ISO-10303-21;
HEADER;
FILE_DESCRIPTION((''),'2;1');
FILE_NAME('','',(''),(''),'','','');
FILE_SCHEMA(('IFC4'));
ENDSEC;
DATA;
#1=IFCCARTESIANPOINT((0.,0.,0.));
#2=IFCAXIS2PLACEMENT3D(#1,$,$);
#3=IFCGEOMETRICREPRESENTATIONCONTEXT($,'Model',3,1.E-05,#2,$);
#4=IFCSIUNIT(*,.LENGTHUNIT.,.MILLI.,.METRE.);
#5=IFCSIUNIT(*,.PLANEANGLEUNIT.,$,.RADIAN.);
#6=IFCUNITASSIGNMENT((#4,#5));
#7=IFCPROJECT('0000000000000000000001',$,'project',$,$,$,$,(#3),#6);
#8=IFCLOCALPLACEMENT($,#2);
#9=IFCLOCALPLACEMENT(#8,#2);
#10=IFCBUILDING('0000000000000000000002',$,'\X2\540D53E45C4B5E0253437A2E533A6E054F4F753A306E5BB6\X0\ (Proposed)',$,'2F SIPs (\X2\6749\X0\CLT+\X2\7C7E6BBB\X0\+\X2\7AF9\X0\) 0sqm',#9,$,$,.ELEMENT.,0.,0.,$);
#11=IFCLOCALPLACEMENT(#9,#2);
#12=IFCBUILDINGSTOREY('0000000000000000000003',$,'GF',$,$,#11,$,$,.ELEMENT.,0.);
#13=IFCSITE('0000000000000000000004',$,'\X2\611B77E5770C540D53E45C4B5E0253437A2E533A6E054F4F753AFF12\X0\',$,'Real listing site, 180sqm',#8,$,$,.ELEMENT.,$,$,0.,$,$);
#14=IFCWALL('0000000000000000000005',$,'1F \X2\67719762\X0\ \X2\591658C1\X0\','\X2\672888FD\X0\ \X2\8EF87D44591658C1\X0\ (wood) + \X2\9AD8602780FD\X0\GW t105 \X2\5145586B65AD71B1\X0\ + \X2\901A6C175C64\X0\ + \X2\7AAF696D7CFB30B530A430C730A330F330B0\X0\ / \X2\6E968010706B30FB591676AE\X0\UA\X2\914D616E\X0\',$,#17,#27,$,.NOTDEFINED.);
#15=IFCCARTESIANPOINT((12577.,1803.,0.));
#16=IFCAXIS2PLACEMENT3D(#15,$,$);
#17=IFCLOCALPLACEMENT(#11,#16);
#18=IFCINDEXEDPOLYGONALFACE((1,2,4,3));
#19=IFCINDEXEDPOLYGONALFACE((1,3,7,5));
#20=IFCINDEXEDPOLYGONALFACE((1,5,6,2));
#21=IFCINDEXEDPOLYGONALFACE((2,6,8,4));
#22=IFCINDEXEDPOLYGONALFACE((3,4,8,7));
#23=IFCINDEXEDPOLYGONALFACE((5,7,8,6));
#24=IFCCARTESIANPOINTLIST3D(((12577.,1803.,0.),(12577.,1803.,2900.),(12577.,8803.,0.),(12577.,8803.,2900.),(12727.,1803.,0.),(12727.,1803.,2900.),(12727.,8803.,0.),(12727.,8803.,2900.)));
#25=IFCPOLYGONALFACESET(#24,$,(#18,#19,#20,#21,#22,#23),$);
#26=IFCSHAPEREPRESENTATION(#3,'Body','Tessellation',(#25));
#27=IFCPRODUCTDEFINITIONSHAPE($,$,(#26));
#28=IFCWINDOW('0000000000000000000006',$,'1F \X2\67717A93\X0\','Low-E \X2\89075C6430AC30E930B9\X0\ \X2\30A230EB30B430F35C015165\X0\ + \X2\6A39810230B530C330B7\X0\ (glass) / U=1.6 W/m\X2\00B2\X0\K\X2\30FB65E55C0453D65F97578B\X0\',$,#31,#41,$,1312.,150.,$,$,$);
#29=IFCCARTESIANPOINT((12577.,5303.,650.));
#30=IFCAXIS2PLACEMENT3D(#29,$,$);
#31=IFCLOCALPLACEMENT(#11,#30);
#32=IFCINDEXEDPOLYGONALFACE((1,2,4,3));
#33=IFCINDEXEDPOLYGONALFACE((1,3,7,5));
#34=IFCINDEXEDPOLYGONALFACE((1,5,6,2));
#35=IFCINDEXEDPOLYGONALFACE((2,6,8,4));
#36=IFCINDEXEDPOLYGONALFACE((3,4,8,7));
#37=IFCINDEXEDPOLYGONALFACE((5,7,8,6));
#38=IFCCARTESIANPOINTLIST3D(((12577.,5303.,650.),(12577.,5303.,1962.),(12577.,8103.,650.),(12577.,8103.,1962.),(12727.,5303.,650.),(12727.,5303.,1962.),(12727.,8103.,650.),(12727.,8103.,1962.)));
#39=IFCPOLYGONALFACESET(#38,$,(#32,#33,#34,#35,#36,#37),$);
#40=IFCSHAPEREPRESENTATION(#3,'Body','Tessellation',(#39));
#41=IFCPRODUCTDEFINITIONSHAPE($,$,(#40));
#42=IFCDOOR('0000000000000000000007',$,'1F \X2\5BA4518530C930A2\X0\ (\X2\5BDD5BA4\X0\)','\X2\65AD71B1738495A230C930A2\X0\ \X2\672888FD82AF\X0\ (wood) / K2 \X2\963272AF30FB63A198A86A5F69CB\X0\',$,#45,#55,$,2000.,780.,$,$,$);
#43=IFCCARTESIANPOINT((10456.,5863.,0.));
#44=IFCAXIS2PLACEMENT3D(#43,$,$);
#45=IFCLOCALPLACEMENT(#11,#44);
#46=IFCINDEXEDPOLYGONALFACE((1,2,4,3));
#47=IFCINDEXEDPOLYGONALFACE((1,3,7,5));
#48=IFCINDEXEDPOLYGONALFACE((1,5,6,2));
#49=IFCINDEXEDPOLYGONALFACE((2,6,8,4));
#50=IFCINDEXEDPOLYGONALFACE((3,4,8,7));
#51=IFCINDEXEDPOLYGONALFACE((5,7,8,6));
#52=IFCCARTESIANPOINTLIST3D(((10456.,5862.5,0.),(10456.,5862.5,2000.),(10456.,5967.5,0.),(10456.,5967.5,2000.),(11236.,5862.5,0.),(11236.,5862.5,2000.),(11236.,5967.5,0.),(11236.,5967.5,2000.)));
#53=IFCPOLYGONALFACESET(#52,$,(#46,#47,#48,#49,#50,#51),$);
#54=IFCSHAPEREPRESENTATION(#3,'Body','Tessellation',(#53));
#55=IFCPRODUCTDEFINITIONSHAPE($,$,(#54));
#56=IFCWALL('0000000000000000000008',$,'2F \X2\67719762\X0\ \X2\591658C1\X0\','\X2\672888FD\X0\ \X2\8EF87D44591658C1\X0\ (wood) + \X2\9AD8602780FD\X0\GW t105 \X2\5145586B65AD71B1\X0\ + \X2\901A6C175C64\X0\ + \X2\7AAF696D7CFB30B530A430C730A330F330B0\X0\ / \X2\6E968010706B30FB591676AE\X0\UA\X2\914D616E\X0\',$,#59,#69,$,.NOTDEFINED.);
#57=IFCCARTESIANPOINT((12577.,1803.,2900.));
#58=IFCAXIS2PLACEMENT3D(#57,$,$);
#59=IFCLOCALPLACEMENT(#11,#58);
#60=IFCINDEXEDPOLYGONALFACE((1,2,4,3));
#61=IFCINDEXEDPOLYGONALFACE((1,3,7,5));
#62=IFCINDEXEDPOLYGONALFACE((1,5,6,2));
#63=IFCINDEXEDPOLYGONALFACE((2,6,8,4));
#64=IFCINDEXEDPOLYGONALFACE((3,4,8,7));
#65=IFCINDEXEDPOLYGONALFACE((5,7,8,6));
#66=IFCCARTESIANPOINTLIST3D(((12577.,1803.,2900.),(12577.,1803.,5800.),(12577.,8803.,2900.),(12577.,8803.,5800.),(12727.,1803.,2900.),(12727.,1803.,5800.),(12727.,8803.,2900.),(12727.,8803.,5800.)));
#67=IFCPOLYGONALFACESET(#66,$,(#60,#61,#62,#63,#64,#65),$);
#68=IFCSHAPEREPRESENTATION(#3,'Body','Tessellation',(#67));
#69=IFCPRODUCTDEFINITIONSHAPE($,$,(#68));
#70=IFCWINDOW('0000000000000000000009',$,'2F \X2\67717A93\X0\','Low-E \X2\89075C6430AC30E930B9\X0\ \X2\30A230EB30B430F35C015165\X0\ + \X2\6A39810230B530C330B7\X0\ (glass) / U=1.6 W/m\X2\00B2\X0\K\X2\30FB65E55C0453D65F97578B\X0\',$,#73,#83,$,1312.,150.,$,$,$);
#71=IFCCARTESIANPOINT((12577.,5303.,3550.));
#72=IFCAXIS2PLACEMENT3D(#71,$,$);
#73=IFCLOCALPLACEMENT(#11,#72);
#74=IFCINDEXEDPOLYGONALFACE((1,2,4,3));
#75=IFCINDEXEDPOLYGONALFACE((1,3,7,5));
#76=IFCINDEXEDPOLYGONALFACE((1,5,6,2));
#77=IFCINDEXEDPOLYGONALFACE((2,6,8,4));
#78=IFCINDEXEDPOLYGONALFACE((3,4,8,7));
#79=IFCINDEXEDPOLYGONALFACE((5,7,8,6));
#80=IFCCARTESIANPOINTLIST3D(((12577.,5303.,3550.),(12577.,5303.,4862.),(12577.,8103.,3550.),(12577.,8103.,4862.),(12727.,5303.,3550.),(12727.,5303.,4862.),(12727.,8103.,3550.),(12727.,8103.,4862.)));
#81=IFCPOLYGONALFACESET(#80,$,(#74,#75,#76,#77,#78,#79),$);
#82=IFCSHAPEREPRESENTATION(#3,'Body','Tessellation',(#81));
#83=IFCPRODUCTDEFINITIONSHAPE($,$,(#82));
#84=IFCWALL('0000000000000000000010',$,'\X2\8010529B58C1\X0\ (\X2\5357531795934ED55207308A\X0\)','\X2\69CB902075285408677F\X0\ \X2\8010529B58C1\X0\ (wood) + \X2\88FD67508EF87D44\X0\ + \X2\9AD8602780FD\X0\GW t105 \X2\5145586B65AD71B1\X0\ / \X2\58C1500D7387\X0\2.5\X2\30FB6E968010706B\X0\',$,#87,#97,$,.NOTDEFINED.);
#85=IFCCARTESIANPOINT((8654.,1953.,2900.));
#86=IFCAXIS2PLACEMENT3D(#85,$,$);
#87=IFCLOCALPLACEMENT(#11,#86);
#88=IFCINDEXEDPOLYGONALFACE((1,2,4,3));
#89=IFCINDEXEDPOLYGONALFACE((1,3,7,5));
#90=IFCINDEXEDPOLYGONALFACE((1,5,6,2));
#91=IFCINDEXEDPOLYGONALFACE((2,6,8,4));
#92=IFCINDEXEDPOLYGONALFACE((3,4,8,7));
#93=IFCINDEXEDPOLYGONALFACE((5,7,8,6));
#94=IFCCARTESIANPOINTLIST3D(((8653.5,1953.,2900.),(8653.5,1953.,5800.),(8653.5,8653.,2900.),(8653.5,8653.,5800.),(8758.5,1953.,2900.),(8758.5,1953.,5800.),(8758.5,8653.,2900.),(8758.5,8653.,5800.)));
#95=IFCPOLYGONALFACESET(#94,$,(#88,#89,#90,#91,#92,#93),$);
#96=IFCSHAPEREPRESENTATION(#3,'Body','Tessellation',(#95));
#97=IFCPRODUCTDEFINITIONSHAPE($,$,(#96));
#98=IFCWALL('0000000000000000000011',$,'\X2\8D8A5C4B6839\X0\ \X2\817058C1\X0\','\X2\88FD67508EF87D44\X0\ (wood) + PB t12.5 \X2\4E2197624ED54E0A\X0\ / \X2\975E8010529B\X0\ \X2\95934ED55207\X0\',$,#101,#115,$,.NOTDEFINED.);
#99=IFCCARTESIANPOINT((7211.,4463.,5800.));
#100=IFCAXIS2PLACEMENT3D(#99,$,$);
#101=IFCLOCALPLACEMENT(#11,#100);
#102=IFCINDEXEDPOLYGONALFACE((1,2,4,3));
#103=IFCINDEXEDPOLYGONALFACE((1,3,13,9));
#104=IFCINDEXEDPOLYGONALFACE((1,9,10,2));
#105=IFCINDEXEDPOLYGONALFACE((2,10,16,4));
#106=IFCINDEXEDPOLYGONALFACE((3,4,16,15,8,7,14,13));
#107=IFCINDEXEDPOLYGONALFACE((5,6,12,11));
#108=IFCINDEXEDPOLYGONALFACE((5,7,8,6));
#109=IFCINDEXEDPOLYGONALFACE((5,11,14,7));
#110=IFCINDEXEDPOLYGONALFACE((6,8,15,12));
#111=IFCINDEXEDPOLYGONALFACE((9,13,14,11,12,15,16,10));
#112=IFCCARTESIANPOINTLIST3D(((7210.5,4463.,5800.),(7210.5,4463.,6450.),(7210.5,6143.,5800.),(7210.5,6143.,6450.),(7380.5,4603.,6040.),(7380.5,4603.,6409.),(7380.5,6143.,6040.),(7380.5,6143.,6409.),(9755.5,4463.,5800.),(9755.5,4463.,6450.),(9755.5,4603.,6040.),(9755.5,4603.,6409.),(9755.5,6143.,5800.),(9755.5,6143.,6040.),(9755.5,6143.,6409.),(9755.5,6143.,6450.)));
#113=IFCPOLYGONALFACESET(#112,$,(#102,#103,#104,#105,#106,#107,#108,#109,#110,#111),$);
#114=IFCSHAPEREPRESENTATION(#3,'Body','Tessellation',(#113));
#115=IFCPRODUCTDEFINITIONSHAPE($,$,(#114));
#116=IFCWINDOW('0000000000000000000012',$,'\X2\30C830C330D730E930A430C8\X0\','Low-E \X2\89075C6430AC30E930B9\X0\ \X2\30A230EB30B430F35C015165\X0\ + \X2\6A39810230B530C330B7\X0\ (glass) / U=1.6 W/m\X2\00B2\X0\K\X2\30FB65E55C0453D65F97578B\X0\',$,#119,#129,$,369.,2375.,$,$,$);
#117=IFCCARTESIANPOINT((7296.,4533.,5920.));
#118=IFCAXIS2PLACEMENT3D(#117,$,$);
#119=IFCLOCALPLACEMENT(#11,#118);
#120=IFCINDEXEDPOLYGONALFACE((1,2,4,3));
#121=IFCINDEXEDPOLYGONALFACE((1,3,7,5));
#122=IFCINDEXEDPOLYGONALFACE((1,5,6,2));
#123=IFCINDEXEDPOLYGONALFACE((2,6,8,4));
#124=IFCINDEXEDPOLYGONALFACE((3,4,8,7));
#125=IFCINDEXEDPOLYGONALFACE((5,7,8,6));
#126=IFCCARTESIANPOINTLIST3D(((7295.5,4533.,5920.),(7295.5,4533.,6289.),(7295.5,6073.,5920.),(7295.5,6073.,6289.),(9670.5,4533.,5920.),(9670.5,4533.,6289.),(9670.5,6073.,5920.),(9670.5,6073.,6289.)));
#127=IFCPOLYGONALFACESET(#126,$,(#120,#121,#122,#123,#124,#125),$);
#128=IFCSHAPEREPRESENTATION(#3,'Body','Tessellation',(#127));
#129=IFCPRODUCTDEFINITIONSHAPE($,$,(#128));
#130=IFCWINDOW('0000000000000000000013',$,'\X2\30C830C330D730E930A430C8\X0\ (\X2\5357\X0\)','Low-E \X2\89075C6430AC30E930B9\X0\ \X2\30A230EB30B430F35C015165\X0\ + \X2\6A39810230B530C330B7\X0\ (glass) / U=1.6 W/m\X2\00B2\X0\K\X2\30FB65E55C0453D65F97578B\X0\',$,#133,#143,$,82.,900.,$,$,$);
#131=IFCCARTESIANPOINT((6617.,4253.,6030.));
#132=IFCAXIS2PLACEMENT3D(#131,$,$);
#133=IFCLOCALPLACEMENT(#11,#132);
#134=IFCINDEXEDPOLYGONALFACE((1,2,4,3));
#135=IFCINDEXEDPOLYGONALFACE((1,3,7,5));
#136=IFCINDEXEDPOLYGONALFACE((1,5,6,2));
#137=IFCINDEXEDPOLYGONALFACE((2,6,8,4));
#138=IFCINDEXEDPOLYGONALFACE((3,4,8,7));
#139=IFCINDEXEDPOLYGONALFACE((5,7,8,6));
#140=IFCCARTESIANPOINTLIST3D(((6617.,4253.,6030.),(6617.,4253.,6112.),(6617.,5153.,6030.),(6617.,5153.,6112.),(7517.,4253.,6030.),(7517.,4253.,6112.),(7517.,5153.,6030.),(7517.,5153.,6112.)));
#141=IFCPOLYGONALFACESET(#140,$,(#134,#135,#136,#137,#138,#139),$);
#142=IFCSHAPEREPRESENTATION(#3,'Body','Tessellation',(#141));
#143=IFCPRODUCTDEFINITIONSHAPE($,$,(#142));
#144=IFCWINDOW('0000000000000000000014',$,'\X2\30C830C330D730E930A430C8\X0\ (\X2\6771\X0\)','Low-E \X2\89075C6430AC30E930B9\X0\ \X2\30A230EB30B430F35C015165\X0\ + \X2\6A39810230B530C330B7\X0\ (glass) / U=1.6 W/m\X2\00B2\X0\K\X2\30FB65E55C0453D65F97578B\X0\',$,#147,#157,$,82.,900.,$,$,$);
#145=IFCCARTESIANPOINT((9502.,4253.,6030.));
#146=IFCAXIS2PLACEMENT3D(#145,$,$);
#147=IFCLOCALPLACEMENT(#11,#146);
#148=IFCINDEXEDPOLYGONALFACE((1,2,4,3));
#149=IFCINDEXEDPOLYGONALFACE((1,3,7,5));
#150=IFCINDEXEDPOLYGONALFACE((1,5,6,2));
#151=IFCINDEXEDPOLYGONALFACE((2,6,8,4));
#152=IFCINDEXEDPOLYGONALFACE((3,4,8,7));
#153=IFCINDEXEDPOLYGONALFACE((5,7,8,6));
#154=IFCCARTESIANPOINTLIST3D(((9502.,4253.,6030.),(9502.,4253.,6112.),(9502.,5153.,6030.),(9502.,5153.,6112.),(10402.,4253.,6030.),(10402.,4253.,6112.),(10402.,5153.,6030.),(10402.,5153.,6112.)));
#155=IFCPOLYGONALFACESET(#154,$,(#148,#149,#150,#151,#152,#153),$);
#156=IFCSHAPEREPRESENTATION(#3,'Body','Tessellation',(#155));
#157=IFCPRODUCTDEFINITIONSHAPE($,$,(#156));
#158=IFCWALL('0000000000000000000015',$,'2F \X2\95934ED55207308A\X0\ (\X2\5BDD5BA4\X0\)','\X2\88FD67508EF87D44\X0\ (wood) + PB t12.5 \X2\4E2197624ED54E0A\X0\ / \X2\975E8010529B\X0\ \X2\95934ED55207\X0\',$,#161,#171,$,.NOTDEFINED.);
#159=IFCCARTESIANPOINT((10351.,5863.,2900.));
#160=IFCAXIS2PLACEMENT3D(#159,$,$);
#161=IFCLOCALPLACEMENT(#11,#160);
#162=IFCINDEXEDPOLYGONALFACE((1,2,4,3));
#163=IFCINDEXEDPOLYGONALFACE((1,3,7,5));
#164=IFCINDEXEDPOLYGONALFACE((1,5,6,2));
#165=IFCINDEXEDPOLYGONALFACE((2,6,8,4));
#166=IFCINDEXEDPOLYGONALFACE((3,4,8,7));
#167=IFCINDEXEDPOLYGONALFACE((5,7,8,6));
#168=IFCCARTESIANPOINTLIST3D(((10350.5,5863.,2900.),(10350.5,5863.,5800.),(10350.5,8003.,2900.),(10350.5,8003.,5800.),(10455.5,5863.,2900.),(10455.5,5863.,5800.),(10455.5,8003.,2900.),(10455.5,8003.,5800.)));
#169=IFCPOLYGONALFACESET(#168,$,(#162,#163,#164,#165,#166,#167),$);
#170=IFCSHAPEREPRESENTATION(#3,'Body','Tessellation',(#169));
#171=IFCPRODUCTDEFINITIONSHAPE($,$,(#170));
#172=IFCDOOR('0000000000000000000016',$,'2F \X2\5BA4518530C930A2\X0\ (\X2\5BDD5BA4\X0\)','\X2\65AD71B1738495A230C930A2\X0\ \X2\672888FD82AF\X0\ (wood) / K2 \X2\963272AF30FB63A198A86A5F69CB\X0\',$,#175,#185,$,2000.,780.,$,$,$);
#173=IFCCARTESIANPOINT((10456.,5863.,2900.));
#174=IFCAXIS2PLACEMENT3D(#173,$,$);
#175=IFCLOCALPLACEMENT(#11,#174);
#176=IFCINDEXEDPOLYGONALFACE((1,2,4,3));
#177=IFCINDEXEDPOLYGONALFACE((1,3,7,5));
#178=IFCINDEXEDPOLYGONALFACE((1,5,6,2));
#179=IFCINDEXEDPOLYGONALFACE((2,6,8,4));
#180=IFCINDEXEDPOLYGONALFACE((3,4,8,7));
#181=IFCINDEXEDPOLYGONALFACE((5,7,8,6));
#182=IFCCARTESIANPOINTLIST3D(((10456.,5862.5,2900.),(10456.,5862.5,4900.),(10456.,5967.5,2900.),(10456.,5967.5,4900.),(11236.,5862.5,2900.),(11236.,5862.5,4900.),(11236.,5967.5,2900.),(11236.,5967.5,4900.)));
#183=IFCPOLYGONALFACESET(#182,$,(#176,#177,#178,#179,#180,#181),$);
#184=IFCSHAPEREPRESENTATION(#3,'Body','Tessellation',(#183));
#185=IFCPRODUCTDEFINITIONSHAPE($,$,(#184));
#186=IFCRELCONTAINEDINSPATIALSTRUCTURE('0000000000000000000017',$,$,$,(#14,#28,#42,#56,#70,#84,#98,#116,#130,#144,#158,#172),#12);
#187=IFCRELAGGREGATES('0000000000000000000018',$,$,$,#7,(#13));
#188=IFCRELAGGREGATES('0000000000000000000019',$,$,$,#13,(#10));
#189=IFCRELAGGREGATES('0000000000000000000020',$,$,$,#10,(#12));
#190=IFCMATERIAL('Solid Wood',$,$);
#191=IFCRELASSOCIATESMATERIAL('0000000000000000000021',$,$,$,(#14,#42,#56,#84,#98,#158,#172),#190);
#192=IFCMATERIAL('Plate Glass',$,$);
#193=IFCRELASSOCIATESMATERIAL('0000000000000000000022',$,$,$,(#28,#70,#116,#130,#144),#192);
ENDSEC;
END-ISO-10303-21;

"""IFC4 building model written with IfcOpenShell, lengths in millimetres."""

from ifc_helpers import new_model, si_unit, frame, frame_2d, origin, place, context, project, spatial, rectangle, extrude, material, element, fill, save


model = new_model("IFC4")

# Units and contexts
model_context = context("Model", 3, precision=1e-05, world=origin())
ifc_project = project(units=[si_unit("LENGTHUNIT", "METRE", prefix="MILLI"), si_unit("PLANEANGLEUNIT", "RADIAN")], contexts=[model_context])

# Site, building, storey
site_placement = place(None, origin())
site = spatial("IfcSite", under=ifc_project, at=site_placement, Name="愛知県名古屋市千種区清住町２", ObjectType="Real listing site, 180sqm", CompositionType="ELEMENT", RefElevation=0.0)
building_placement = place(site_placement, origin())
building = spatial("IfcBuilding", under=site, at=building_placement, Name="名古屋市千種区清住町の家 (Proposed)", ObjectType="2F SIPs (杉CLT+籾殻+竹) 0sqm", CompositionType="ELEMENT", ElevationOfRefHeight=0.0, ElevationOfTerrain=0.0)
storey_placement = place(building_placement, origin())
storey = spatial("IfcBuildingStorey", under=building, at=storey_placement, Name="GF", CompositionType="ELEMENT", Elevation=0.0)

# Wall, opening, window
ifc_material_1 = material(Name="Solid Wood")
wall_1_placement = place(storey_placement, frame((12577.0, 1803.0, 0.0)))
wall_1 = element("IfcWall", 1, at=wall_1_placement, inside=storey, material=ifc_material_1, Name="1F 東面 外壁", Description="木製 軸組外壁 (wood) + 高性能GW t105 充填断熱 + 通気層 + 窯業系サイディング / 準耐火・外皮UA配慮", PredefinedType="NOTDEFINED", context=model_context, shape_type="SweptSolid", body=[
    extrude(rectangle(XDim=150.0, YDim=7000.0, at=frame_2d((75.0, 3500.0))), frame((12577.0, 1803.0, 0.0)), (0.0, 0.0, 1.0), 2900.0),
])
opening_1_placement = place(storey_placement, frame((12577.0, 5303.0, 650.0)))
opening_1 = element("IfcOpeningElement", 2, at=opening_1_placement, cuts=wall_1, PredefinedType="NOTDEFINED", context=model_context, shape_type="SweptSolid", body=[
    extrude(rectangle(XDim=150.0, YDim=2800.0, at=frame_2d((75.0, 1400.0))), frame((12577.0, 5303.0, 650.0)), (0.0, 0.0, 1.0), 1312.0),
])
ifc_material_2 = material(Name="Plate Glass")
window_1_placement = place(storey_placement, frame((12577.0, 5303.0, 650.0)))
window_1 = element("IfcWindow", 3, at=window_1_placement, inside=storey, material=ifc_material_2, Name="1F 東窓", Description="Low-E 複層ガラス アルゴン封入 + 樹脂サッシ (glass) / U=1.6 W/m²K・日射取得型", OverallHeight=1312.0, OverallWidth=150.0, context=model_context, shape_type="SweptSolid", body=[
    extrude(rectangle(XDim=150.0, YDim=2800.0, at=frame_2d((75.0, 1400.0))), frame((12577.0, 5303.0, 650.0)), (0.0, 0.0, 1.0), 1312.0),
])
fill(opening_1, window_1)

# Door
door_1_placement = place(storey_placement, frame((10456.0, 5863.0, 0.0)))
element("IfcDoor", 4, at=door_1_placement, inside=storey, material=ifc_material_1, Name="1F 室内ドア (寝室)", Description="断熱玄関ドア 木製芯 (wood) / K2 防犯・採風機構", OverallHeight=2000.0, OverallWidth=780.0, context=model_context, shape_type="SweptSolid", body=[
    extrude(rectangle(XDim=780.0, YDim=105.0, at=frame_2d((390.0, 52.0))), frame((10456.0, 5863.0, 0.0)), (0.0, 0.0, 1.0), 2000.0),
])

# Wall, opening, window
wall_2_placement = place(storey_placement, frame((12577.0, 1803.0, 2900.0)))
wall_2 = element("IfcWall", 5, at=wall_2_placement, inside=storey, material=ifc_material_1, Name="2F 東面 外壁", Description="木製 軸組外壁 (wood) + 高性能GW t105 充填断熱 + 通気層 + 窯業系サイディング / 準耐火・外皮UA配慮", PredefinedType="NOTDEFINED", context=model_context, shape_type="SweptSolid", body=[
    extrude(rectangle(XDim=150.0, YDim=7000.0, at=frame_2d((75.0, 3500.0))), frame((12577.0, 1803.0, 2900.0)), (0.0, 0.0, 1.0), 2900.0),
])
opening_2_placement = place(storey_placement, frame((12577.0, 5303.0, 3550.0)))
opening_2 = element("IfcOpeningElement", 6, at=opening_2_placement, cuts=wall_2, PredefinedType="NOTDEFINED", context=model_context, shape_type="SweptSolid", body=[
    extrude(rectangle(XDim=150.0, YDim=2800.0, at=frame_2d((75.0, 1400.0))), frame((12577.0, 5303.0, 3550.0)), (0.0, 0.0, 1.0), 1312.0),
])
window_2_placement = place(storey_placement, frame((12577.0, 5303.0, 3550.0)))
window_2 = element("IfcWindow", 7, at=window_2_placement, inside=storey, material=ifc_material_2, Name="2F 東窓", Description="Low-E 複層ガラス アルゴン封入 + 樹脂サッシ (glass) / U=1.6 W/m²K・日射取得型", OverallHeight=1312.0, OverallWidth=150.0, context=model_context, shape_type="SweptSolid", body=[
    extrude(rectangle(XDim=150.0, YDim=2800.0, at=frame_2d((75.0, 1400.0))), frame((12577.0, 5303.0, 3550.0)), (0.0, 0.0, 1.0), 1312.0),
])
fill(opening_2, window_2)

# Wall
wall_3_placement = place(storey_placement, frame((8654.0, 1953.0, 2900.0)))
element("IfcWall", 8, at=wall_3_placement, inside=storey, material=ifc_material_1, Name="耐力壁 (南北間仕切り)", Description="構造用合板 耐力壁 (wood) + 製材軸組 + 高性能GW t105 充填断熱 / 壁倍率2.5・準耐火", PredefinedType="NOTDEFINED", context=model_context, shape_type="SweptSolid", body=[
    extrude(rectangle(XDim=105.0, YDim=6700.0, at=frame_2d((52.0, 3350.0))), frame((8654.0, 1953.0, 2900.0)), (0.0, 0.0, 1.0), 2900.0),
])

# Wall, openings, windows
wall_4_placement = place(storey_placement, frame((7211.0, 4463.0, 5800.0)))
wall_4 = element("IfcWall", 9, at=wall_4_placement, inside=storey, material=ifc_material_1, Name="越屋根 腰壁", Description="製材軸組 (wood) + PB t12.5 両面仕上 / 非耐力 間仕切", PredefinedType="NOTDEFINED", context=model_context, shape_type="SweptSolid", body=[
    extrude(rectangle(XDim=2545.0, YDim=1680.0, at=frame_2d((1272.0, 840.0))), frame((7211.0, 4463.0, 5800.0)), (0.0, 0.0, 1.0), 650.0),
])
opening_3_placement = place(storey_placement, frame((7296.0, 4533.0, 5920.0)))
opening_3 = element("IfcOpeningElement", 10, at=opening_3_placement, cuts=wall_4, PredefinedType="NOTDEFINED", context=model_context, shape_type="SweptSolid", body=[
    extrude(rectangle(XDim=2375.0, YDim=1540.0, at=frame_2d((1187.0, 770.0))), frame((7296.0, 4533.0, 5920.0)), (0.0, 0.0, 1.0), 369.0),
])
opening_4_placement = place(storey_placement, frame((6617.0, 4253.0, 6030.0)))
opening_4 = element("IfcOpeningElement", 11, at=opening_4_placement, cuts=wall_4, PredefinedType="NOTDEFINED", context=model_context, shape_type="SweptSolid", body=[
    extrude(rectangle(XDim=900.0, YDim=900.0, at=frame_2d((450.0, 450.0))), frame((6617.0, 4253.0, 6030.0)), (0.0, 0.0, 1.0), 82.0),
])
opening_5_placement = place(storey_placement, frame((9502.0, 4253.0, 6030.0)))
opening_5 = element("IfcOpeningElement", 12, at=opening_5_placement, cuts=wall_4, PredefinedType="NOTDEFINED", context=model_context, shape_type="SweptSolid", body=[
    extrude(rectangle(XDim=900.0, YDim=900.0, at=frame_2d((450.0, 450.0))), frame((9502.0, 4253.0, 6030.0)), (0.0, 0.0, 1.0), 82.0),
])
window_3_placement = place(storey_placement, frame((7296.0, 4533.0, 5920.0)))
window_3 = element("IfcWindow", 13, at=window_3_placement, inside=storey, material=ifc_material_2, Name="トップライト", Description="Low-E 複層ガラス アルゴン封入 + 樹脂サッシ (glass) / U=1.6 W/m²K・日射取得型", OverallHeight=369.0, OverallWidth=2375.0, context=model_context, shape_type="SweptSolid", body=[
    extrude(rectangle(XDim=2375.0, YDim=1540.0, at=frame_2d((1187.0, 770.0))), frame((7296.0, 4533.0, 5920.0)), (0.0, 0.0, 1.0), 369.0),
])
fill(opening_3, window_3)
window_4_placement = place(storey_placement, frame((6617.0, 4253.0, 6030.0)))
window_4 = element("IfcWindow", 14, at=window_4_placement, inside=storey, material=ifc_material_2, Name="トップライト (南)", Description="Low-E 複層ガラス アルゴン封入 + 樹脂サッシ (glass) / U=1.6 W/m²K・日射取得型", OverallHeight=82.0, OverallWidth=900.0, context=model_context, shape_type="SweptSolid", body=[
    extrude(rectangle(XDim=900.0, YDim=900.0, at=frame_2d((450.0, 450.0))), frame((6617.0, 4253.0, 6030.0)), (0.0, 0.0, 1.0), 82.0),
])
fill(opening_4, window_4)
window_5_placement = place(storey_placement, frame((9502.0, 4253.0, 6030.0)))
window_5 = element("IfcWindow", 15, at=window_5_placement, inside=storey, material=ifc_material_2, Name="トップライト (東)", Description="Low-E 複層ガラス アルゴン封入 + 樹脂サッシ (glass) / U=1.6 W/m²K・日射取得型", OverallHeight=82.0, OverallWidth=900.0, context=model_context, shape_type="SweptSolid", body=[
    extrude(rectangle(XDim=900.0, YDim=900.0, at=frame_2d((450.0, 450.0))), frame((9502.0, 4253.0, 6030.0)), (0.0, 0.0, 1.0), 82.0),
])
fill(opening_5, window_5)

# Wall
wall_5_placement = place(storey_placement, frame((10351.0, 5863.0, 2900.0)))
element("IfcWall", 16, at=wall_5_placement, inside=storey, material=ifc_material_1, Name="2F 間仕切り (寝室)", Description="製材軸組 (wood) + PB t12.5 両面仕上 / 非耐力 間仕切", PredefinedType="NOTDEFINED", context=model_context, shape_type="SweptSolid", body=[
    extrude(rectangle(XDim=105.0, YDim=2140.0, at=frame_2d((52.0, 1070.0))), frame((10351.0, 5863.0, 2900.0)), (0.0, 0.0, 1.0), 2900.0),
])

# Door
door_2_placement = place(storey_placement, frame((10456.0, 5863.0, 2900.0)))
element("IfcDoor", 17, at=door_2_placement, inside=storey, material=ifc_material_1, Name="2F 室内ドア (寝室)", Description="断熱玄関ドア 木製芯 (wood) / K2 防犯・採風機構", OverallHeight=2000.0, OverallWidth=780.0, context=model_context, shape_type="SweptSolid", body=[
    extrude(rectangle(XDim=780.0, YDim=105.0, at=frame_2d((390.0, 52.0))), frame((10456.0, 5863.0, 2900.0)), (0.0, 0.0, 1.0), 2000.0),
])

save(model, "model.ifc")
